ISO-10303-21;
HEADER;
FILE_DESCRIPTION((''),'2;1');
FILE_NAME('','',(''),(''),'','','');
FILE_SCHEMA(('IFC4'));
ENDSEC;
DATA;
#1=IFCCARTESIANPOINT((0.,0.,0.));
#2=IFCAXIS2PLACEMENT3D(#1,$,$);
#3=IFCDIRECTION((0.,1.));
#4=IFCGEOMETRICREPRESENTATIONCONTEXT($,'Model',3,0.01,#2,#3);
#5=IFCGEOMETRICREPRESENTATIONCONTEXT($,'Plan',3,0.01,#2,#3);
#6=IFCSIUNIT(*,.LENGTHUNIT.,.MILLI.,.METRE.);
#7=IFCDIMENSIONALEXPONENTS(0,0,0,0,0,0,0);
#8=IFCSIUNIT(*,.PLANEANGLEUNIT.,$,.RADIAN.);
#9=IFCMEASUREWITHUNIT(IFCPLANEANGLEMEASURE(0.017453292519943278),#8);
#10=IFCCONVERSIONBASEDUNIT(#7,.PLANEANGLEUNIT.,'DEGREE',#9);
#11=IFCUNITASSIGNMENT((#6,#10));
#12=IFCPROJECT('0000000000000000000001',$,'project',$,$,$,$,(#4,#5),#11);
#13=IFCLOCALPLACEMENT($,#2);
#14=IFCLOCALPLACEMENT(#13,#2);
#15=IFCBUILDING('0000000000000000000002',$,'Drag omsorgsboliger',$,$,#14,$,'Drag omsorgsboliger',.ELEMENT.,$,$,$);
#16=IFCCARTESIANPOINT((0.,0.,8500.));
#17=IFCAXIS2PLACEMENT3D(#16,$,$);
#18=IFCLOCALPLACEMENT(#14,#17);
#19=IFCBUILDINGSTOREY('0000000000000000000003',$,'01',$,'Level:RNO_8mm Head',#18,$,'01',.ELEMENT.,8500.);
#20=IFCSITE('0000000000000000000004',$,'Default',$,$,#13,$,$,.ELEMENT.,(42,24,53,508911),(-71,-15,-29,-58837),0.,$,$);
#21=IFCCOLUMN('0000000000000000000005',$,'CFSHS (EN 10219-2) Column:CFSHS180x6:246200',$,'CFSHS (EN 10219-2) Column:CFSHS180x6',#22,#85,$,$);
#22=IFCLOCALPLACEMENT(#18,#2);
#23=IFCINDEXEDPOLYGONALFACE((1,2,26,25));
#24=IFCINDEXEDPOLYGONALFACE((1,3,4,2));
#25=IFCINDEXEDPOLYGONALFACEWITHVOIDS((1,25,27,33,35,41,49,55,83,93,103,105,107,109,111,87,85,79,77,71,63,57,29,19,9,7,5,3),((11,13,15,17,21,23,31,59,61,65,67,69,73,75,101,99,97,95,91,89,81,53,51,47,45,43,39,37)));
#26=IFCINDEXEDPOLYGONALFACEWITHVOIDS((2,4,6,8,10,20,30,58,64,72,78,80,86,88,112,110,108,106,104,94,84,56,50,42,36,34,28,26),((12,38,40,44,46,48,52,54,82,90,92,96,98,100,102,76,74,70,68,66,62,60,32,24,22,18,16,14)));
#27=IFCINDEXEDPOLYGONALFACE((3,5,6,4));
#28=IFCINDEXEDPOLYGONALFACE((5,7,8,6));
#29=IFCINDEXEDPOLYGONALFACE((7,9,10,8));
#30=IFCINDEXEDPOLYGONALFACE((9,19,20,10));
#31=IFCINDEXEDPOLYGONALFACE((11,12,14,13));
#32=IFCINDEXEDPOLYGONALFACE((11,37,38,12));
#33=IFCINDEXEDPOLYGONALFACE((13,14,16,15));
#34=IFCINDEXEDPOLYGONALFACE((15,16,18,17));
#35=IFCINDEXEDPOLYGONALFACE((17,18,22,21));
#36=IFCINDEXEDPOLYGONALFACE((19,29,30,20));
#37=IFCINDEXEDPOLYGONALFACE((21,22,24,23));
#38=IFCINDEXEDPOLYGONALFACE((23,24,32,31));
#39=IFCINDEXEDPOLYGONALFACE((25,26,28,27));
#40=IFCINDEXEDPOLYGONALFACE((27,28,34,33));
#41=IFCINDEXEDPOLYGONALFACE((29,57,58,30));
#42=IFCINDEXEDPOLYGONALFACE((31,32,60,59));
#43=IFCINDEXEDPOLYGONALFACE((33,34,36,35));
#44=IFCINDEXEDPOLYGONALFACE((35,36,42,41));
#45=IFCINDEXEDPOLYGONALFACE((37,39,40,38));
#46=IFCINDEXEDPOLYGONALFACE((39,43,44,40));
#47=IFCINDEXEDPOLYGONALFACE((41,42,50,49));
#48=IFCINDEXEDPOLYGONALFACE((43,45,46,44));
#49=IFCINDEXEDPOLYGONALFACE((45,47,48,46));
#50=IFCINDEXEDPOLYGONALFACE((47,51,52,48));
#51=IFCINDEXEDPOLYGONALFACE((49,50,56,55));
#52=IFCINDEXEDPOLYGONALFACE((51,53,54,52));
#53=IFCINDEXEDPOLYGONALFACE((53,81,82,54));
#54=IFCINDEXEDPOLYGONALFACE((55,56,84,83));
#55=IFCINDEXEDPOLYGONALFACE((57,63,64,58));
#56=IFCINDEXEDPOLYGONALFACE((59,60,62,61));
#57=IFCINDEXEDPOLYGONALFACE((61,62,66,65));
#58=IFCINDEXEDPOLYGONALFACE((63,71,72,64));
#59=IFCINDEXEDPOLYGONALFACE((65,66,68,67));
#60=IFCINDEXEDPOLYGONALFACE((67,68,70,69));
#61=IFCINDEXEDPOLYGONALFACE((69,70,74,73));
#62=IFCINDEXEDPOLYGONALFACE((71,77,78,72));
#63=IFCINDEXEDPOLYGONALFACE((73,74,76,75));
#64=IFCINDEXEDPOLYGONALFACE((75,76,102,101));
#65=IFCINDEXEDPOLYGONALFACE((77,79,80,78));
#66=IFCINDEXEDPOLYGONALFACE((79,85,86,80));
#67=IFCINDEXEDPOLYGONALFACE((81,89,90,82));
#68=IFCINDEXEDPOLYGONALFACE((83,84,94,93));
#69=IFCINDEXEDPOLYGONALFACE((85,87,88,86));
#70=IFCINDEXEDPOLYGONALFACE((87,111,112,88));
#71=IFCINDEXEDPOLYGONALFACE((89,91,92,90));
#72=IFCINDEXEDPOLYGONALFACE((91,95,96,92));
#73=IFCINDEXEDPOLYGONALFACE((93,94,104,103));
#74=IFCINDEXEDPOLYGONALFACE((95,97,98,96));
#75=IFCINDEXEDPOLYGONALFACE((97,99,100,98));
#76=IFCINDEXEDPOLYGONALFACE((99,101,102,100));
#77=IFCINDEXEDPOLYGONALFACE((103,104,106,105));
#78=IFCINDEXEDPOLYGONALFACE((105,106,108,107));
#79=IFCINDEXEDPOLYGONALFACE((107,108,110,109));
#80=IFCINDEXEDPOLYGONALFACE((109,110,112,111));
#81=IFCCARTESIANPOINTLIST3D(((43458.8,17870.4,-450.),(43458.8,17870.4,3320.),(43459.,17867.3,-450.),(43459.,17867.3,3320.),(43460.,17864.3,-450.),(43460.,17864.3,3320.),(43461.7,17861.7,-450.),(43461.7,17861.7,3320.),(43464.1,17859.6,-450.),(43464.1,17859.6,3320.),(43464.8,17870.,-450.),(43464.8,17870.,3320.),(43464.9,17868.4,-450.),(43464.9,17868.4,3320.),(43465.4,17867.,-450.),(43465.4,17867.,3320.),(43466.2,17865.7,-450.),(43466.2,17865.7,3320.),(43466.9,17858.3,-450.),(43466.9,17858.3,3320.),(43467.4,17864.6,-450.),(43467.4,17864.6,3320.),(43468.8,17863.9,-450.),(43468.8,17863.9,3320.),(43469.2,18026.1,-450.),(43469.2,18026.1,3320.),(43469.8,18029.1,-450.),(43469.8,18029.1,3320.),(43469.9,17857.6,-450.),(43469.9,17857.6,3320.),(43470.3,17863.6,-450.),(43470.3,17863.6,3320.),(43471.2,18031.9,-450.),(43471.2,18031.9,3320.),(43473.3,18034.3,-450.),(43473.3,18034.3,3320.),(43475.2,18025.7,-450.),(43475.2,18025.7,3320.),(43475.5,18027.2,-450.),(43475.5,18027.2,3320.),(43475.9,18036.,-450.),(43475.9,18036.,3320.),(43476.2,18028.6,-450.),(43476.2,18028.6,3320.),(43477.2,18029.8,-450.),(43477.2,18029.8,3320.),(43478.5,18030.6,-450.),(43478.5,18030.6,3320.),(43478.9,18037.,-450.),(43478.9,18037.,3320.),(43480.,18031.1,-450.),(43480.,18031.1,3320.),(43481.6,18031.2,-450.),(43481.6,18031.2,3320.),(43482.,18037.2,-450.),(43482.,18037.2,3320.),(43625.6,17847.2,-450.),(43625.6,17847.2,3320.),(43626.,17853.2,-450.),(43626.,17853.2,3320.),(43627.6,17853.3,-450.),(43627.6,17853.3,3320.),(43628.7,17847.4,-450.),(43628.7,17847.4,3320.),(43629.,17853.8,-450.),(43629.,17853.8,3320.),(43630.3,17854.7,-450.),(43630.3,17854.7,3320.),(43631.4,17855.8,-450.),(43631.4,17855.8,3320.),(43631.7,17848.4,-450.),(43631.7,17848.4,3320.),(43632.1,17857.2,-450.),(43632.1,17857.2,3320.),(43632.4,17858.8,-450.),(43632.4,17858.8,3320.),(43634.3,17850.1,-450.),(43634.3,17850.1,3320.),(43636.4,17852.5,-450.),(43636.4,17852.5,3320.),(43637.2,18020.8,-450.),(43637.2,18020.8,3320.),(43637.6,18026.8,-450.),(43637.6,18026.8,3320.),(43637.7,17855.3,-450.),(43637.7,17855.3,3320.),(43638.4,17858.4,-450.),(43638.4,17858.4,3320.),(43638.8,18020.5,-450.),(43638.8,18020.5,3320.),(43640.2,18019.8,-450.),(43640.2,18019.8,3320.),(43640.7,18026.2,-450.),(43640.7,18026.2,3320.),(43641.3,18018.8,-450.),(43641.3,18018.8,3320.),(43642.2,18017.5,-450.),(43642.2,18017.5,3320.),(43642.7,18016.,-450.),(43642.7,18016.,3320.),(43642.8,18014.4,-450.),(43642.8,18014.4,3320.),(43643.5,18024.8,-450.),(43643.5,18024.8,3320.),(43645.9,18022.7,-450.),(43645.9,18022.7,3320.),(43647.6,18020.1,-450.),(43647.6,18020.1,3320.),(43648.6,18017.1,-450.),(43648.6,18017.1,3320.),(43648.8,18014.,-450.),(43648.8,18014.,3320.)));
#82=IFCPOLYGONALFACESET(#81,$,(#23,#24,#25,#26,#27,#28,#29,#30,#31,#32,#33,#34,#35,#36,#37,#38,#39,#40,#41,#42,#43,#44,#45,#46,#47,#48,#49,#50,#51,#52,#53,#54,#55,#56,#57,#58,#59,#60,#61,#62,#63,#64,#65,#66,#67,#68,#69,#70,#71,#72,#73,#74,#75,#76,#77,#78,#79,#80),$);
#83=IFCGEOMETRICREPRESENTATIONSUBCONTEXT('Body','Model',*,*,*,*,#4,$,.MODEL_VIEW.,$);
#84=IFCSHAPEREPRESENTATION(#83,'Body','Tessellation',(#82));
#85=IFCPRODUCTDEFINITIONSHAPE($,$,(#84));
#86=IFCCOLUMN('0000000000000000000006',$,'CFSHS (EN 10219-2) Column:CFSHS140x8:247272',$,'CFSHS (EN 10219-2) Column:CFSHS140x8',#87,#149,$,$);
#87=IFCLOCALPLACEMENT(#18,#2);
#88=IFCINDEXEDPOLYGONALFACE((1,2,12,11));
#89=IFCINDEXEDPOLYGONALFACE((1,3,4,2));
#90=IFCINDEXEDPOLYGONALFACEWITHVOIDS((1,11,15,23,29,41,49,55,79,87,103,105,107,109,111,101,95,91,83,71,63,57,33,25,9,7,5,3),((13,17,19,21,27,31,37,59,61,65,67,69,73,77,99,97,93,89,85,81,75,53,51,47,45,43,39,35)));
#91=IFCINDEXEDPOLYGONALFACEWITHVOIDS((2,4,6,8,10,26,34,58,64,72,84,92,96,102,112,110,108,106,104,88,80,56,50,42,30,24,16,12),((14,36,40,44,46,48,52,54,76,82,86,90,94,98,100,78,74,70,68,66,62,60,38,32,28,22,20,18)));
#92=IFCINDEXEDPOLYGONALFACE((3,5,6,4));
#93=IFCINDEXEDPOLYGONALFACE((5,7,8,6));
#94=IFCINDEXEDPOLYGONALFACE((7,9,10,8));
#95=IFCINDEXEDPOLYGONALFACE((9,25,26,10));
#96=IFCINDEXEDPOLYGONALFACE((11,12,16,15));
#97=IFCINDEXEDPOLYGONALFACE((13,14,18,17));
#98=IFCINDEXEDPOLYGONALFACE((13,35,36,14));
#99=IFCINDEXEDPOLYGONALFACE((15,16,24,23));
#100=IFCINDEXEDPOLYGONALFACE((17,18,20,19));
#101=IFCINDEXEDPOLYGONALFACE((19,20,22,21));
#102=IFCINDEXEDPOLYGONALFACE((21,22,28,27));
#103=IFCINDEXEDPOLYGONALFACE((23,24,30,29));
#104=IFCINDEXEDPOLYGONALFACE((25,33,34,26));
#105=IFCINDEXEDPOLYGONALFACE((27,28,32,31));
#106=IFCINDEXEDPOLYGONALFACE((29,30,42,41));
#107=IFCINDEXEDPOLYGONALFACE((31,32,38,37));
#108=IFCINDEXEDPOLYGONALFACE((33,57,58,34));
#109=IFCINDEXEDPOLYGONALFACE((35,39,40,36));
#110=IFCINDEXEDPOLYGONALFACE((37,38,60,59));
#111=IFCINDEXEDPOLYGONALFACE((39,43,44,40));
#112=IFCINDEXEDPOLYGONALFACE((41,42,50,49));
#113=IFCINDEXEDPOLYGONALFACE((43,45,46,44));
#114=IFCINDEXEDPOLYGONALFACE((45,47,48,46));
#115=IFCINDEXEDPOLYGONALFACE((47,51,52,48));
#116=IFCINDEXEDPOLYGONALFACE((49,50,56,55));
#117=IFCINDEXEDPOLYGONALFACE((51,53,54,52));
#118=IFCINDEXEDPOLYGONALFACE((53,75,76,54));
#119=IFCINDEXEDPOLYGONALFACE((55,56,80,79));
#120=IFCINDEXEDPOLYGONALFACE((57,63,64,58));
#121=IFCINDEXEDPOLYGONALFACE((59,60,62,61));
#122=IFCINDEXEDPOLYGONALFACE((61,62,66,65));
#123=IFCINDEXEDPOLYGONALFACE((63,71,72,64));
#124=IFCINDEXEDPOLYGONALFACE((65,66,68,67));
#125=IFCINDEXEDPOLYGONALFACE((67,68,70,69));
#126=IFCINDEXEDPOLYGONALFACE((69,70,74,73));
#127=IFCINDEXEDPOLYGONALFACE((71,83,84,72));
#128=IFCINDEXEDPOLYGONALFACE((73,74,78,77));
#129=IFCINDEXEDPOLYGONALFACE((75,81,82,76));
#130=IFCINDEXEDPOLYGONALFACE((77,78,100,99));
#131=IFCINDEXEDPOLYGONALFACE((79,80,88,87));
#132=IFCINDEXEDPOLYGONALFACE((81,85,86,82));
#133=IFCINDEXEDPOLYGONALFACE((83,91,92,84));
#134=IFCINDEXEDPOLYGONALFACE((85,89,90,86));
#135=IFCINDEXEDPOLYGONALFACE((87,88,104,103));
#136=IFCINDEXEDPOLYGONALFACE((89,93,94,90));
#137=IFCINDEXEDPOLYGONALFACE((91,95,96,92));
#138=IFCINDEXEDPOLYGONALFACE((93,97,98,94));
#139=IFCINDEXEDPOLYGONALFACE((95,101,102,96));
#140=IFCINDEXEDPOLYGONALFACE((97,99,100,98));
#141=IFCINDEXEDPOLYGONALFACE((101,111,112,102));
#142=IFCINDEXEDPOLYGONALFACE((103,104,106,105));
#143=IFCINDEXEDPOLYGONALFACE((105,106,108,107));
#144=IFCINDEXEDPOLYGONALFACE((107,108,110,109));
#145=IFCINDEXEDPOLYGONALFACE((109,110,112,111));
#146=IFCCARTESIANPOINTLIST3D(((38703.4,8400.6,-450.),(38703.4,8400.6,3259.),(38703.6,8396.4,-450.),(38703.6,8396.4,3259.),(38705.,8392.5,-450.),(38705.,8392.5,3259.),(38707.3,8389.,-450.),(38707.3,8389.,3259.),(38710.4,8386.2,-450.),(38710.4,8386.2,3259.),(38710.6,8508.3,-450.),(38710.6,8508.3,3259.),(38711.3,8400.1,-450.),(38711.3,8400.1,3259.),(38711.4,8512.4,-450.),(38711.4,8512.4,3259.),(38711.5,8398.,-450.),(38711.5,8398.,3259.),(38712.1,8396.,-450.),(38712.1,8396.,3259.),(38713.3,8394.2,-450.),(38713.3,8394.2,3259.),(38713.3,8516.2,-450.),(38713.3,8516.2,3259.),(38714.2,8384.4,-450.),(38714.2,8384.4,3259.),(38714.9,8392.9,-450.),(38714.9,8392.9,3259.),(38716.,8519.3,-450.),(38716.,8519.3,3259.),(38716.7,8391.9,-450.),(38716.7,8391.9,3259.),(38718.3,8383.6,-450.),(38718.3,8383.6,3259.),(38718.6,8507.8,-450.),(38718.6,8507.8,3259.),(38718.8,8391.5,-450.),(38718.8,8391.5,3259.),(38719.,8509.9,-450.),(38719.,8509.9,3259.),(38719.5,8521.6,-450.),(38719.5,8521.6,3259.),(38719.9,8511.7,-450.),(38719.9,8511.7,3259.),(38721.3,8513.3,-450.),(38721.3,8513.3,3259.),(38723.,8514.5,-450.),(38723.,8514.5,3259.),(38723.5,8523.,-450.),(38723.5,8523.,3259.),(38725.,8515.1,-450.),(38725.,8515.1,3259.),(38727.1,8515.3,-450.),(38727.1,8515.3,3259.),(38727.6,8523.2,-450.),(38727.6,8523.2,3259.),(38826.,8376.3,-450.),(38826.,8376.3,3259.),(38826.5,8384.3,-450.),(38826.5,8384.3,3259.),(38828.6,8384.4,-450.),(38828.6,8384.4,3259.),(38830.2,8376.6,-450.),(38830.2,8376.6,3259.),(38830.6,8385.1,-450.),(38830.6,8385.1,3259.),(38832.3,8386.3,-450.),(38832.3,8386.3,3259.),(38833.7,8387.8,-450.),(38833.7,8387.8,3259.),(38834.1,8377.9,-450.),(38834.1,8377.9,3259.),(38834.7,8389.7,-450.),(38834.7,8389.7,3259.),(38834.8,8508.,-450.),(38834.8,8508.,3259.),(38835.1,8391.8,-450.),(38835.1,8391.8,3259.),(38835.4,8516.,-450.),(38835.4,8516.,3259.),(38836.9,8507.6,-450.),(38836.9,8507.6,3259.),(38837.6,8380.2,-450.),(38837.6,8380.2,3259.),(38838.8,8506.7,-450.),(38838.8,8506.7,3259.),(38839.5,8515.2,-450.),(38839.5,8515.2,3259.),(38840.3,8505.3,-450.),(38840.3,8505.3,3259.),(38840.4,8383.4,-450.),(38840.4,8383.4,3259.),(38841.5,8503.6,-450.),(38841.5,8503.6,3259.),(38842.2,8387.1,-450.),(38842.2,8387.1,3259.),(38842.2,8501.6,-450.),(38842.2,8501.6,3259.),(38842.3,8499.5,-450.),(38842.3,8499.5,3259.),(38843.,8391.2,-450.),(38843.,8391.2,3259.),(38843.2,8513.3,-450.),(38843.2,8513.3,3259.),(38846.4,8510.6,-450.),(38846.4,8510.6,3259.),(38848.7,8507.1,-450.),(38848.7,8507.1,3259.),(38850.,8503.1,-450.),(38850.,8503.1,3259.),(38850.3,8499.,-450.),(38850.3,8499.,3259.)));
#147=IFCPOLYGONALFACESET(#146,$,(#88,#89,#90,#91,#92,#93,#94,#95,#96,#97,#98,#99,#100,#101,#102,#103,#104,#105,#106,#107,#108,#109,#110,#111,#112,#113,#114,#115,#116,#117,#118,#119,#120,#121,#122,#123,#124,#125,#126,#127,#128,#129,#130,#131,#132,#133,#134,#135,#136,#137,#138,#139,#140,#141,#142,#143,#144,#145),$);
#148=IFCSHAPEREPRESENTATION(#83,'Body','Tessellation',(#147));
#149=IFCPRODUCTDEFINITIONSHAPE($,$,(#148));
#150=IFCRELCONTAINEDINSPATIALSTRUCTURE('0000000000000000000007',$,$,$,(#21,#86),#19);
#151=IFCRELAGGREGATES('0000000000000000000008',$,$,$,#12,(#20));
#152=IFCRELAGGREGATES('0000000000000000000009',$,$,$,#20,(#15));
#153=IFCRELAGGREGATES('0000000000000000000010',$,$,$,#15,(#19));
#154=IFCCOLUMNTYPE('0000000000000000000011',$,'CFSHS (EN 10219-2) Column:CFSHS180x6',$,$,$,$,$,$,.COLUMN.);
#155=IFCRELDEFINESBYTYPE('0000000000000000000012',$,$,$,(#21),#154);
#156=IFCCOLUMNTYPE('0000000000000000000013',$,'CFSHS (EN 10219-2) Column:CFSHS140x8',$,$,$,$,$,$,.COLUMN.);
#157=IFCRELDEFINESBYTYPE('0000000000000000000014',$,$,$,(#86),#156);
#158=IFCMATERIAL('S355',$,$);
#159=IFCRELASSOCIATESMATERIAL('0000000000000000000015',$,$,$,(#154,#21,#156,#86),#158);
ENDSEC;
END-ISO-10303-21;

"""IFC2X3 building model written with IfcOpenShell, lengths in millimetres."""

from ifc_helpers import new_model, entity, si_unit, converted_unit, direction, frame, frame_2d, origin, place, context, subcontext, project, spatial, polyline, circle_curve, parameter, trimmed, segment, composite_curve, outline, extrude, source, transform, mapped, material, type_object, type_shapes, element, save


model = new_model("IFC2X3")

# Units and contexts
model_context = context("Model", 3, precision=0.01, world=origin(), true_north=direction((0.0, 1.0)))
plan_context = context("Plan", 3, precision=0.01, world=origin(), true_north=direction((0.0, 1.0)))
body_context = subcontext(model_context, "Body", "Model", "MODEL_VIEW")
ifc_project = project(units=[si_unit("LENGTHUNIT", "METRE", prefix="MILLI"), converted_unit("PLANEANGLEUNIT", "DEGREE", entity("IfcPlaneAngleMeasure", 0.017453292519943278), si_unit("PLANEANGLEUNIT", "RADIAN"), dimensions=[0, 0, 0, 0, 0, 0, 0])], contexts=[model_context, plan_context])

# Site, building, storey
site_placement = place(None, origin())
site = spatial("IfcSite", under=ifc_project, at=site_placement, Name="Default", CompositionType="ELEMENT", RefLatitude=(42, 24, 53, 508911), RefLongitude=(-71, -15, -29, -58837), RefElevation=0.0)
building_placement = place(site_placement, origin())
building = spatial("IfcBuilding", under=site, at=building_placement, Name="Drag omsorgsboliger", LongName="Drag omsorgsboliger", CompositionType="ELEMENT")
storey_placement = place(building_placement, frame((0.0, 0.0, 8500.0)))
storey = spatial("IfcBuildingStorey", under=building, at=storey_placement, Name="01", ObjectType="Level:RNO_8mm Head", LongName="01", CompositionType="ELEMENT", Elevation=8500.0)

# Columns
ifc_material = material(Name="S355")
column_type_1 = type_object("IfcColumnType", Name="CFSHS (EN 10219-2) Column:CFSHS180x6", PredefinedType="COLUMN", material=ifc_material)
shared_shape_1 = source(origin(), body_context, "Body", "SweptSolid", [
    extrude(outline(composite_curve([segment(polyline([(-78.0, -90.0), (78.0, -90.0)]), True, "CONTINUOUS"), segment(trimmed(circle_curve(frame_2d((78.0, -78.0), x_axis=(-1.0, 0.0)), 12.0), [parameter(90.0)], [parameter(180.0)], True, "PARAMETER"), True, "CONTINUOUS"), segment(polyline([(90.0, -78.0), (90.0, 78.0)]), True, "CONTINUOUS"), segment(trimmed(circle_curve(frame_2d((78.0, 78.0), x_axis=(-1.0, 0.0)), 12.0), [parameter(180.0)], [parameter(270.0)], True, "PARAMETER"), True, "CONTINUOUS"), segment(polyline([(78.0, 90.0), (-78.0, 90.0)]), True, "CONTINUOUS"), segment(trimmed(circle_curve(frame_2d((-78.0, 78.0), x_axis=(-1.0, 0.0)), 12.0), [parameter(270.0)], [parameter(360.0)], True, "PARAMETER"), True, "CONTINUOUS"), segment(polyline([(-90.0, 78.0), (-90.0, -78.0)]), True, "CONTINUOUS"), segment(trimmed(circle_curve(frame_2d((-78.0, -78.0), x_axis=(-1.0, 0.0)), 12.0), [parameter(360.0)], [parameter(90.0)], True, "PARAMETER"), True, "CONTINUOUS")], self_intersect=False), holes=[composite_curve([segment(trimmed(circle_curve(frame_2d((-78.0, -78.0), x_axis=(-1.0, 0.0)), 6.0), [parameter(360.0)], [parameter(90.0)], True, "PARAMETER"), False, "CONTINUOUS"), segment(polyline([(-84.0, -78.0), (-84.0, 78.0)]), True, "CONTINUOUS"), segment(trimmed(circle_curve(frame_2d((-78.0, 78.0), x_axis=(-1.0, 0.0)), 6.0), [parameter(270.0)], [parameter(360.0)], True, "PARAMETER"), False, "CONTINUOUS"), segment(polyline([(-78.0, 84.0), (78.0, 84.0)]), True, "CONTINUOUS"), segment(trimmed(circle_curve(frame_2d((78.0, 78.0), x_axis=(-1.0, 0.0)), 6.0), [parameter(180.0)], [parameter(270.0)], True, "PARAMETER"), False, "CONTINUOUS"), segment(polyline([(84.0, 78.0), (84.0, -78.0)]), True, "CONTINUOUS"), segment(trimmed(circle_curve(frame_2d((78.0, -78.0), x_axis=(-1.0, 0.0)), 6.0), [parameter(90.0)], [parameter(180.0)], True, "PARAMETER"), False, "CONTINUOUS"), segment(polyline([(78.0, -84.0), (-78.0, -84.0)]), True, "CONTINUOUS")], self_intersect=False)]), frame((43553.8, 17942.2, 8050.0), z_axis=(0.0, 0.0, 1.0), x_axis=(-0.997758, 0.066923, 0.0)), (0.0, 0.0, 1.0), 3770.0),
])
type_shapes(column_type_1, [shared_shape_1])
column_1_placement = place(storey_placement, frame((0.0, 0.0, -8500.0)))
element("IfcColumn", 1, at=column_1_placement, inside=storey, type_object=column_type_1, material=ifc_material, Name="CFSHS (EN 10219-2) Column:CFSHS180x6:246200", ObjectType="CFSHS (EN 10219-2) Column:CFSHS180x6", context=body_context, shape_type="MappedRepresentation", body=[
    mapped(shared_shape_1, transform((0.0, 0.0, 0.0), scale=1.0)),
])
column_type_2 = type_object("IfcColumnType", Name="CFSHS (EN 10219-2) Column:CFSHS140x8", PredefinedType="COLUMN", material=ifc_material)
shared_shape_2 = source(origin(), body_context, "Body", "SweptSolid", [
    extrude(outline(composite_curve([segment(polyline([(-54.0, -70.0), (54.0, -70.0)]), True, "CONTINUOUS"), segment(trimmed(circle_curve(frame_2d((54.0, -54.0), x_axis=(-1.0, 0.0)), 16.0), [parameter(90.0)], [parameter(180.0)], True, "PARAMETER"), True, "CONTINUOUS"), segment(polyline([(70.0, -54.0), (70.0, 54.0)]), True, "CONTINUOUS"), segment(trimmed(circle_curve(frame_2d((54.0, 54.0), x_axis=(-1.0, 0.0)), 16.0), [parameter(180.0)], [parameter(270.0)], True, "PARAMETER"), True, "CONTINUOUS"), segment(polyline([(54.0, 70.0), (-54.0, 70.0)]), True, "CONTINUOUS"), segment(trimmed(circle_curve(frame_2d((-54.0, 54.0), x_axis=(-1.0, 0.0)), 16.0), [parameter(270.0)], [parameter(360.0)], True, "PARAMETER"), True, "CONTINUOUS"), segment(polyline([(-70.0, 54.0), (-70.0, -54.0)]), True, "CONTINUOUS"), segment(trimmed(circle_curve(frame_2d((-54.0, -54.0), x_axis=(-1.0, 0.0)), 16.0), [parameter(360.0)], [parameter(90.0)], True, "PARAMETER"), True, "CONTINUOUS")], self_intersect=False), holes=[composite_curve([segment(trimmed(circle_curve(frame_2d((-54.0, -54.0), x_axis=(-1.0, 0.0)), 8.0), [parameter(360.0)], [parameter(90.0)], True, "PARAMETER"), False, "CONTINUOUS"), segment(polyline([(-62.0, -54.0), (-62.0, 54.0)]), True, "CONTINUOUS"), segment(trimmed(circle_curve(frame_2d((-54.0, 54.0), x_axis=(-1.0, 0.0)), 8.0), [parameter(270.0)], [parameter(360.0)], True, "PARAMETER"), False, "CONTINUOUS"), segment(polyline([(-54.0, 62.0), (54.0, 62.0)]), True, "CONTINUOUS"), segment(trimmed(circle_curve(frame_2d((54.0, 54.0), x_axis=(-1.0, 0.0)), 8.0), [parameter(180.0)], [parameter(270.0)], True, "PARAMETER"), False, "CONTINUOUS"), segment(polyline([(62.0, 54.0), (62.0, -54.0)]), True, "CONTINUOUS"), segment(trimmed(circle_curve(frame_2d((54.0, -54.0), x_axis=(-1.0, 0.0)), 8.0), [parameter(90.0)], [parameter(180.0)], True, "PARAMETER"), False, "CONTINUOUS"), segment(polyline([(54.0, -62.0), (-54.0, -62.0)]), True, "CONTINUOUS")], self_intersect=False)]), frame((38776.8, 8449.8, 8050.0), z_axis=(0.0, 0.0, 1.0), x_axis=(-0.997758, 0.066923, 0.0)), (0.0, 0.0, 1.0), 3709.0),
])
type_shapes(column_type_2, [shared_shape_2])
column_2_placement = place(storey_placement, frame((0.0, 0.0, -8500.0)))
element("IfcColumn", 2, at=column_2_placement, inside=storey, type_object=column_type_2, material=ifc_material, Name="CFSHS (EN 10219-2) Column:CFSHS140x8:247272", ObjectType="CFSHS (EN 10219-2) Column:CFSHS140x8", context=body_context, shape_type="MappedRepresentation", body=[
    mapped(shared_shape_2, transform((0.0, 0.0, 0.0), scale=1.0)),
])

save(model, "model.ifc")
